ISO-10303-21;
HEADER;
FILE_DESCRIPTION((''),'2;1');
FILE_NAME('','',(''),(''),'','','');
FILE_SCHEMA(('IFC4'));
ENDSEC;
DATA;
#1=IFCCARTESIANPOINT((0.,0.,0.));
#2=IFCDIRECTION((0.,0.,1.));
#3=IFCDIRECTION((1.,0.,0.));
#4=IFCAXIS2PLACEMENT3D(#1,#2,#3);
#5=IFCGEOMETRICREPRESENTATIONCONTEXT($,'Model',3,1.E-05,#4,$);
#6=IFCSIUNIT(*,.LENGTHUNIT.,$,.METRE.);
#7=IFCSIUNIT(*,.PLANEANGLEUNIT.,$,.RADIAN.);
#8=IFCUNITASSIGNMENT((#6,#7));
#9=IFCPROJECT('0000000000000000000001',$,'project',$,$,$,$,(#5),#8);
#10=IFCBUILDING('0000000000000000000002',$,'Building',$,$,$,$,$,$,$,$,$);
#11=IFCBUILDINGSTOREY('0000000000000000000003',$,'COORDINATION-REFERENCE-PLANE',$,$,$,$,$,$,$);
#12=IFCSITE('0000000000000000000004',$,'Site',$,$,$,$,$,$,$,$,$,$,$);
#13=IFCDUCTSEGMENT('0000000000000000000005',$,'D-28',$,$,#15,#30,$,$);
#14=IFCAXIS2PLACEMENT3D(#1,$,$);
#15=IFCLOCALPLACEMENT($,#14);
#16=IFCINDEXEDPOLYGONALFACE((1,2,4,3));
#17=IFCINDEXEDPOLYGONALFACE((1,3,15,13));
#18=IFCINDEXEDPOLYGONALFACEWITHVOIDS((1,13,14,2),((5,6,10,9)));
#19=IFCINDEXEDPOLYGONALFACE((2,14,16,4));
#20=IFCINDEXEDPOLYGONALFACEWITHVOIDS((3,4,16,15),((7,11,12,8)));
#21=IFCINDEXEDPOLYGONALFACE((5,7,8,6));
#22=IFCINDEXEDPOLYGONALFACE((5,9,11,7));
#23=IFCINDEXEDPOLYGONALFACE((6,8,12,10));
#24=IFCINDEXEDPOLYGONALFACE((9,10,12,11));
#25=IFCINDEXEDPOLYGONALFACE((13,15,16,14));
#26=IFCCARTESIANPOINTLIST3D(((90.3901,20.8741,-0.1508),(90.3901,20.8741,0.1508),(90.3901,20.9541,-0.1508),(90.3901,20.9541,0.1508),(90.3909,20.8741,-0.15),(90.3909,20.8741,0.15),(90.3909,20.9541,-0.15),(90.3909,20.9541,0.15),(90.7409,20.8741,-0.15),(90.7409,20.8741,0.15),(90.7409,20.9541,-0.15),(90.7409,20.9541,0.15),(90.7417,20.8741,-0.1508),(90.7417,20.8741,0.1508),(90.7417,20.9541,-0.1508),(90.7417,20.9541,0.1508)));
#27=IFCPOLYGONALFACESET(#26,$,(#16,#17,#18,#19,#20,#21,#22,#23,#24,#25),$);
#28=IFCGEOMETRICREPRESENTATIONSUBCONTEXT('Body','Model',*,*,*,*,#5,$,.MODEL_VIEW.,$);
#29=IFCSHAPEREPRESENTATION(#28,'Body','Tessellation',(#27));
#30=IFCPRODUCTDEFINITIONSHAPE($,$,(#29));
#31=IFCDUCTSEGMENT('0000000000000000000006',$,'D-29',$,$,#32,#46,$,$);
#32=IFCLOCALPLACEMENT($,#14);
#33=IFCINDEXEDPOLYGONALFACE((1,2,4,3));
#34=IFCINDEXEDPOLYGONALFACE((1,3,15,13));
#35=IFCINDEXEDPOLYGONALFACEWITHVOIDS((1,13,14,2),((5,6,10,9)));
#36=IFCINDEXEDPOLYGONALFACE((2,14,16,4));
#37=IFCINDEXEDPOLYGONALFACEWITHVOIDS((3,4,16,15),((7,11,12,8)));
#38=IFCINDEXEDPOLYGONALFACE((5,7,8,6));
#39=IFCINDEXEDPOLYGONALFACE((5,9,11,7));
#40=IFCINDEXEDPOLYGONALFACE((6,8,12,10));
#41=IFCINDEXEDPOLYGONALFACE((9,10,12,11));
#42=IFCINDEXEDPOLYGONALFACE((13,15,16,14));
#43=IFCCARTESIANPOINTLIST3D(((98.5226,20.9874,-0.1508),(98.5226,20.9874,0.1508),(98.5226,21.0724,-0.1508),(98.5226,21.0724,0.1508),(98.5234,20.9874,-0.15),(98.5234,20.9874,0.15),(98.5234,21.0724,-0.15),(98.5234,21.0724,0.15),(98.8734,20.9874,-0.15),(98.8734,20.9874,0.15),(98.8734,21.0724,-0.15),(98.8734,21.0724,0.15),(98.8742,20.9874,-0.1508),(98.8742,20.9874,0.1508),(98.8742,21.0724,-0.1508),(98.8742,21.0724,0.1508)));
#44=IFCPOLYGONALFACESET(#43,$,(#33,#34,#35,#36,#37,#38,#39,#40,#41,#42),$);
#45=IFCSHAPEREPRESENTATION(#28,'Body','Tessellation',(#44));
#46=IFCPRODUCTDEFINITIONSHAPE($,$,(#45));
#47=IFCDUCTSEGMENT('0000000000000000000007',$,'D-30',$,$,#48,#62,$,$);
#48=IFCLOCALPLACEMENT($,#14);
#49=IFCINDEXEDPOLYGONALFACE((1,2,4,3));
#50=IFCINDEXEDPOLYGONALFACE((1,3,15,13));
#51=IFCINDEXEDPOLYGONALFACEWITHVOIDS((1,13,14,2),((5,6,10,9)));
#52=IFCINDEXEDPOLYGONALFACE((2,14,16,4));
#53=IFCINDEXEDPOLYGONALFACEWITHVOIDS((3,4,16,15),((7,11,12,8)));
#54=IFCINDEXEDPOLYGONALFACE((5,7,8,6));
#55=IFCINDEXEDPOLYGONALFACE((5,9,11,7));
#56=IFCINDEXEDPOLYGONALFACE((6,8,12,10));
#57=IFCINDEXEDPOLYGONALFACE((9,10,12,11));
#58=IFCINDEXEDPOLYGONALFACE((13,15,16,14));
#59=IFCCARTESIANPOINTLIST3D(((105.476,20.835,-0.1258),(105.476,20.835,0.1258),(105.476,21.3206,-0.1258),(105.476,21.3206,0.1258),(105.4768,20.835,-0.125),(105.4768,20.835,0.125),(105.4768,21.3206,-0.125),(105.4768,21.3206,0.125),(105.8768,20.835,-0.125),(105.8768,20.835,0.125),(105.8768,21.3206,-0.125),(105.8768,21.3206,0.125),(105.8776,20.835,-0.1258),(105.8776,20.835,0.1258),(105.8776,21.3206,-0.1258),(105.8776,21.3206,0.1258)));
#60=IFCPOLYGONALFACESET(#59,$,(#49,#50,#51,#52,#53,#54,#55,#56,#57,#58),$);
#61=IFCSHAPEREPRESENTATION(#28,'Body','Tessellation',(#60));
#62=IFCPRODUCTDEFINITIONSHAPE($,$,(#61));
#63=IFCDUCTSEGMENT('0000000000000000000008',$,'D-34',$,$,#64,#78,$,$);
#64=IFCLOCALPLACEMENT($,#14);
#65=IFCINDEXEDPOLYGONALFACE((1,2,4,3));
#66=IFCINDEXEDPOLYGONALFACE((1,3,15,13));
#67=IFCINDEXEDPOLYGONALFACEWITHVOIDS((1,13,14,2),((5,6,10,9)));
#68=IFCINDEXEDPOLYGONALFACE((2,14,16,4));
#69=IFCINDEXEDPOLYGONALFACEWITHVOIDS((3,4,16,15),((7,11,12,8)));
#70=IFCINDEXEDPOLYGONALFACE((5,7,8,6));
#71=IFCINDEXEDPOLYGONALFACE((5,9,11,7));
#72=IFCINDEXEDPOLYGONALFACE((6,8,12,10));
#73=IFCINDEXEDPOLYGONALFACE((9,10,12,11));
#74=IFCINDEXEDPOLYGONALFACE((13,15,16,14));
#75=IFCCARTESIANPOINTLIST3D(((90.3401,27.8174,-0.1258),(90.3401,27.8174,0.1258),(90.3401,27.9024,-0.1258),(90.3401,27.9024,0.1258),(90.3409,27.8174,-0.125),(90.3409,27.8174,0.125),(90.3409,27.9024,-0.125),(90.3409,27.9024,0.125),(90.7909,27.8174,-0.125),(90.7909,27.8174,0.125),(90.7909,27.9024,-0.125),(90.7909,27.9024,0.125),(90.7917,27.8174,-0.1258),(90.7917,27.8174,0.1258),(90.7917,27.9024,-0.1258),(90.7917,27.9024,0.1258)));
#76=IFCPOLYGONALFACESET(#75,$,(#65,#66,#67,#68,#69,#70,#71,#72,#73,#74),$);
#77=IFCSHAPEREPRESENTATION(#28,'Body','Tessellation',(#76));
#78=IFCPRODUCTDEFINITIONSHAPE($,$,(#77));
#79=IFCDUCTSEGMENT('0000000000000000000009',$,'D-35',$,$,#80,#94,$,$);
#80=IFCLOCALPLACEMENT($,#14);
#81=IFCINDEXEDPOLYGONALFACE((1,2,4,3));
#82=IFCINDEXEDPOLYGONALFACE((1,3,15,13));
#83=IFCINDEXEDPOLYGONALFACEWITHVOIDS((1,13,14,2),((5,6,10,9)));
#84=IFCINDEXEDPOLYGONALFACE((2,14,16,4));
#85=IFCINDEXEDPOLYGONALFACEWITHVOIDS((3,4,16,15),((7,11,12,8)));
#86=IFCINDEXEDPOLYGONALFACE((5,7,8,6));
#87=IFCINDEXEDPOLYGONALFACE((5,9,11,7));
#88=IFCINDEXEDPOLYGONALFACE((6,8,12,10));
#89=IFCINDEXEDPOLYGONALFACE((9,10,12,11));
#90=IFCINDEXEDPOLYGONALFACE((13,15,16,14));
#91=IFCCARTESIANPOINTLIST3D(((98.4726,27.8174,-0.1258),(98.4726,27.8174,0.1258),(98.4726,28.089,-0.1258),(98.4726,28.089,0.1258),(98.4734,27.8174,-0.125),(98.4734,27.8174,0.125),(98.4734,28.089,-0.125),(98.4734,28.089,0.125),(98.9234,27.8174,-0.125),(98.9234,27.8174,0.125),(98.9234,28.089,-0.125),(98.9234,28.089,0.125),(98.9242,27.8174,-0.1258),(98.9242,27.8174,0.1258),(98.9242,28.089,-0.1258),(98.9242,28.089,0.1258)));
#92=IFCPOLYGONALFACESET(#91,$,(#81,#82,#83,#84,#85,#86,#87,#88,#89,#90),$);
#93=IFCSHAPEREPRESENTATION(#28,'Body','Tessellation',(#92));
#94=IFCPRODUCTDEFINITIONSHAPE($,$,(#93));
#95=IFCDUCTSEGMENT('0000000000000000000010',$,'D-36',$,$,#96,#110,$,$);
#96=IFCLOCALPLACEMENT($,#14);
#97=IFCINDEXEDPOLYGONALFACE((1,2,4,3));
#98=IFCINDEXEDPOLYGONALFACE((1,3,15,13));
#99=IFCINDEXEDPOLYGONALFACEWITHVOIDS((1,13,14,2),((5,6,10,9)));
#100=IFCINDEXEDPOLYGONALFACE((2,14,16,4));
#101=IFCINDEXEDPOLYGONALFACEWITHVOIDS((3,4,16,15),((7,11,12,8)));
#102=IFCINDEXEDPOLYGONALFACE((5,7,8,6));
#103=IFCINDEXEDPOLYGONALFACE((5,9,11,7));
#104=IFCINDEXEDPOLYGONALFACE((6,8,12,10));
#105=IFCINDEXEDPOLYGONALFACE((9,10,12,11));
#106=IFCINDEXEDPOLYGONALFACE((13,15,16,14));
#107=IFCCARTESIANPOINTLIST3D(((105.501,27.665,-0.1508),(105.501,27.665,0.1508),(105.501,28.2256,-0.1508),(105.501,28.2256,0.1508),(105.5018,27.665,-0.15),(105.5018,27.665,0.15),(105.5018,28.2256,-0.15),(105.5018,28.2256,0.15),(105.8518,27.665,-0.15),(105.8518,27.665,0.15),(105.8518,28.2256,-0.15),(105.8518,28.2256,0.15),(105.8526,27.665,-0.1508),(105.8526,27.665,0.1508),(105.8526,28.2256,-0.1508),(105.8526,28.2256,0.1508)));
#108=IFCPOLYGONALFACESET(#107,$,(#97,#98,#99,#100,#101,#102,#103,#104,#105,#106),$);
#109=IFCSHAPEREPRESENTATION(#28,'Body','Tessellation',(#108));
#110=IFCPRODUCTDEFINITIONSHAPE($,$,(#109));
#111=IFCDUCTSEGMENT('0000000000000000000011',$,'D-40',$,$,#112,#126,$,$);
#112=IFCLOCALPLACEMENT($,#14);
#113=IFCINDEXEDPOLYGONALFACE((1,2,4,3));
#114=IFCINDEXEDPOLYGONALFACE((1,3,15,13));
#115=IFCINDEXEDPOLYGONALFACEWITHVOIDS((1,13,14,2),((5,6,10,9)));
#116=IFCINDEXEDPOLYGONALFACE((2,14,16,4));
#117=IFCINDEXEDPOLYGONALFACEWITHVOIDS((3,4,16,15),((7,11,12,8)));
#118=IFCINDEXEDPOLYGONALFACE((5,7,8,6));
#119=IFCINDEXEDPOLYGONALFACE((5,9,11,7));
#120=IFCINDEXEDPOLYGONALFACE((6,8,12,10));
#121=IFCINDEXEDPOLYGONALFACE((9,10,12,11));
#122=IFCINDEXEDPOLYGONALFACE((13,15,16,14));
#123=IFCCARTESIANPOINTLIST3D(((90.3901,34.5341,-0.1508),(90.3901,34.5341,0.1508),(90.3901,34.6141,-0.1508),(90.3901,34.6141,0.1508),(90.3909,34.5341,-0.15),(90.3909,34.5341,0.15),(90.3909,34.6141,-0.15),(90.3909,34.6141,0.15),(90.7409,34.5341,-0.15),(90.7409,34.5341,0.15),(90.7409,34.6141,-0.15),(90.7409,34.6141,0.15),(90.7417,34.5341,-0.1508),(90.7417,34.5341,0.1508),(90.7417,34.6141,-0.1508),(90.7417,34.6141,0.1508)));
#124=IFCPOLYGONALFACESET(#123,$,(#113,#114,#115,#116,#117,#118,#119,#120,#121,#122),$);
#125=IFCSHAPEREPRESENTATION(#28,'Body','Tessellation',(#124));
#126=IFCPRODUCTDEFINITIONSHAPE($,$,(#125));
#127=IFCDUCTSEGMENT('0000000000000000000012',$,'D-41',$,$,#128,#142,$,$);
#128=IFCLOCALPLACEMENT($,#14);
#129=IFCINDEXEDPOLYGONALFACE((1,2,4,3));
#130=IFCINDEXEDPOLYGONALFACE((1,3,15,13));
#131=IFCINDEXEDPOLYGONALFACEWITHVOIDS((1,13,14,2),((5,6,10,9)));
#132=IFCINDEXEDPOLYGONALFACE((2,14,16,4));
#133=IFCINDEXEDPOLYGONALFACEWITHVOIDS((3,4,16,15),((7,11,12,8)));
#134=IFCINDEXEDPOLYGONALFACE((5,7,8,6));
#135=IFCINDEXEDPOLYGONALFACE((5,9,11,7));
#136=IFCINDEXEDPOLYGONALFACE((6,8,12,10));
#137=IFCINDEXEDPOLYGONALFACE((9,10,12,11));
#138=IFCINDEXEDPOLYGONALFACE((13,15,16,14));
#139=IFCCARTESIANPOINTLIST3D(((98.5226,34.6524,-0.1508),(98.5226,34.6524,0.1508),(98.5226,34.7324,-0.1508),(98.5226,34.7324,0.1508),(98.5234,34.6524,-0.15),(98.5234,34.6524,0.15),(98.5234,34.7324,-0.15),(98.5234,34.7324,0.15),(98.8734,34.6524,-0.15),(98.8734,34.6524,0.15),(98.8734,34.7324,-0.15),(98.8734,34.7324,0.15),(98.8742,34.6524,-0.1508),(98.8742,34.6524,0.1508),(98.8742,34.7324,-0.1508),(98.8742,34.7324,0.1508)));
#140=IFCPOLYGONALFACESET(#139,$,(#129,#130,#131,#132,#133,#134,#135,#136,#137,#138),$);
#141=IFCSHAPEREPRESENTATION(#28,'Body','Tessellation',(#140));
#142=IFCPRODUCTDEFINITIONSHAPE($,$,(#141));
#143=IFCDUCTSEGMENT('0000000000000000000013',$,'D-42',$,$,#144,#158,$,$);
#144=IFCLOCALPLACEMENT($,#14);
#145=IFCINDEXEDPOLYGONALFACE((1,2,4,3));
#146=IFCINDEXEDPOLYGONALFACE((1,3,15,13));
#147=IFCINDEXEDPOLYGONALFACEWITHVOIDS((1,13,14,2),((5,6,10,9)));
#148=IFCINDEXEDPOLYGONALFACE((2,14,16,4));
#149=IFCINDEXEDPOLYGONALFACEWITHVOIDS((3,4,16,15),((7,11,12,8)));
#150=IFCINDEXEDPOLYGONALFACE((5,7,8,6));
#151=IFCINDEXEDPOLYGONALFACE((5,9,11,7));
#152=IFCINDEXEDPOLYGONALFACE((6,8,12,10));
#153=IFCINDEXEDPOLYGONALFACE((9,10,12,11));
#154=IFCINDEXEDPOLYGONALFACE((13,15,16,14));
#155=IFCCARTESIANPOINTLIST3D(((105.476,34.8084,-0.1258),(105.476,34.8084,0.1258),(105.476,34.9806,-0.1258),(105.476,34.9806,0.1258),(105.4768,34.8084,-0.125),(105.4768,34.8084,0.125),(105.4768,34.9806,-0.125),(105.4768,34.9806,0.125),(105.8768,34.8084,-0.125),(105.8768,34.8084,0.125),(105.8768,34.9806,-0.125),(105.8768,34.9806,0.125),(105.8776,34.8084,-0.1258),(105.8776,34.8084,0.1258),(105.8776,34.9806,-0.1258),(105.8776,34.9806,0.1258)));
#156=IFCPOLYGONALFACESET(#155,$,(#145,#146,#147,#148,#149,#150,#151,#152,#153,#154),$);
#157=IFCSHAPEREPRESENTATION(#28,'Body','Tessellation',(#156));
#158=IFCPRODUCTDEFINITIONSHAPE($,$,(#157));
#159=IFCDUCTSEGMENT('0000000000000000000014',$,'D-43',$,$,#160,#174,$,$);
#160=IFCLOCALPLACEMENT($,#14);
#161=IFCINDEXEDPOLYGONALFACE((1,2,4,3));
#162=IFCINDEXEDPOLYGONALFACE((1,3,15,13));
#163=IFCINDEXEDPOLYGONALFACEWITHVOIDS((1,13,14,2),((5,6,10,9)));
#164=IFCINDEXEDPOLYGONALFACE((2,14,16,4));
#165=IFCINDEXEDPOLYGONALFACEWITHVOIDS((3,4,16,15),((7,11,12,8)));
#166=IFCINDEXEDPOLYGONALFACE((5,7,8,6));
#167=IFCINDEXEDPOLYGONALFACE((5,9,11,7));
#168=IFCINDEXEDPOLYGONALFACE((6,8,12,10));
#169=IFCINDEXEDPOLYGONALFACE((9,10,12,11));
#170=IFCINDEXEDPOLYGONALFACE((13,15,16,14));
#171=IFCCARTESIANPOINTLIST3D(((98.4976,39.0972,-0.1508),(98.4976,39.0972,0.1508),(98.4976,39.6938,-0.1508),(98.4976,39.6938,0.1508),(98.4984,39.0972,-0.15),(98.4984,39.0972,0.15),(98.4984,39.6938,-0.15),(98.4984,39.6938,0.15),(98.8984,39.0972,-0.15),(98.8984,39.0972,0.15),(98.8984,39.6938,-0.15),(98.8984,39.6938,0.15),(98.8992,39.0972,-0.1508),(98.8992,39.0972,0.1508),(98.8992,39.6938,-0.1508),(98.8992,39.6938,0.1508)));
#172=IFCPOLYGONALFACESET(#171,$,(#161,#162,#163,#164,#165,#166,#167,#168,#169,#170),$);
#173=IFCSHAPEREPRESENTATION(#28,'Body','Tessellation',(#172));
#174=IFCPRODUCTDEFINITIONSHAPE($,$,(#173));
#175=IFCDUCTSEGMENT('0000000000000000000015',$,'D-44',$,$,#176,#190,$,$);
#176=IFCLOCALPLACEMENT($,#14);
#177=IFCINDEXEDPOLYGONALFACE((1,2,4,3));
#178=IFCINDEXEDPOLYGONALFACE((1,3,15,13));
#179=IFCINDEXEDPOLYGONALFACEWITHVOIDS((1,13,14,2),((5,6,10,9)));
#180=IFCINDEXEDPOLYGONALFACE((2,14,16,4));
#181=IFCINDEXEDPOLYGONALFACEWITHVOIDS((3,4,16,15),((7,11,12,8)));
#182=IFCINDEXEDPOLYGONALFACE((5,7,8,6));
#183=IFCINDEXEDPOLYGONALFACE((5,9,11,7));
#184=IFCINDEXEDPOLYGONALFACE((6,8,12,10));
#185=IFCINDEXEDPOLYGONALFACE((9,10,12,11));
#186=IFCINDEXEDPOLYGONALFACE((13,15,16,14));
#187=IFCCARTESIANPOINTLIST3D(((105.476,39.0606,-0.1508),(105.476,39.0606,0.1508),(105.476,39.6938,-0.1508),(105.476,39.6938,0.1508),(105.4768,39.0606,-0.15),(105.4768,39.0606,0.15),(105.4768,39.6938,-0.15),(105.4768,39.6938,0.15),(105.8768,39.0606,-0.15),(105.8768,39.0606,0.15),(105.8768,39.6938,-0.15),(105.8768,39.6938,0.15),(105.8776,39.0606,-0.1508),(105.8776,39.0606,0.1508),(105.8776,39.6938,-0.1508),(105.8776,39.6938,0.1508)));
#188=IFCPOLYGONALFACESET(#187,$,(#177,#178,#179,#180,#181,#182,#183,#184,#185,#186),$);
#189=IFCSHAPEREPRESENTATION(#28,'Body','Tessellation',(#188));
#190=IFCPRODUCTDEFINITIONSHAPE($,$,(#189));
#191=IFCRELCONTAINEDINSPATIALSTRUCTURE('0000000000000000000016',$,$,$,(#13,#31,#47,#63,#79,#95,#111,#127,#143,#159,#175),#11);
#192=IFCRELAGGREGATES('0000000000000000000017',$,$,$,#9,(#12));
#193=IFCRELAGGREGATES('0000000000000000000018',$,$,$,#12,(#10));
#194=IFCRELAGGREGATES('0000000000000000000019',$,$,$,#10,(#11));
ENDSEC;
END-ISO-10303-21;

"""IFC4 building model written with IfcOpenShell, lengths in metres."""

from ifc_helpers import new_model, si_unit, frame, origin, origin_with_axes, place, context, subcontext, project, spatial, hollow_rectangle, extrude, element, save


model = new_model("IFC4")

# Units and contexts
model_context = context("Model", 3, precision=1e-05, world=origin_with_axes())
body_context = subcontext(model_context, "Body", "Model", "MODEL_VIEW")
ifc_project = project(units=[si_unit("LENGTHUNIT", "METRE"), si_unit("PLANEANGLEUNIT", "RADIAN")], contexts=[model_context])

# Site, building, storey
site = spatial("IfcSite", under=ifc_project, Name="Site")
building = spatial("IfcBuilding", under=site, Name="Building")
storey = spatial("IfcBuildingStorey", under=building, Name="COORDINATION-REFERENCE-PLANE")

# Duct segments
duct_segment_1_placement = place(None, frame((90.5659, 20.8741, 0.0), z_axis=(0.0, 1.0, 0.0), x_axis=(1.0, 0.0, 0.0)))
element("IfcDuctSegment", 1, at=duct_segment_1_placement, inside=storey, Name="D-28", context=body_context, shape_type="SweptSolid", body=[
    extrude(hollow_rectangle(XDim=0.3516, YDim=0.3016, WallThickness=0.0008), origin(), (0.0, 0.0, 1.0), 0.08),
])
duct_segment_2_placement = place(None, frame((98.6984, 20.9874, 0.0), z_axis=(0.0, 1.0, 0.0), x_axis=(1.0, 0.0, 0.0)))
element("IfcDuctSegment", 2, at=duct_segment_2_placement, inside=storey, Name="D-29", context=body_context, shape_type="SweptSolid", body=[
    extrude(hollow_rectangle(XDim=0.3516, YDim=0.3016, WallThickness=0.0008), origin(), (0.0, 0.0, 1.0), 0.085),
])
duct_segment_3_placement = place(None, frame((105.6768, 20.835, 0.0), z_axis=(0.0, 1.0, 0.0), x_axis=(1.0, 0.0, 0.0)))
element("IfcDuctSegment", 3, at=duct_segment_3_placement, inside=storey, Name="D-30", context=body_context, shape_type="SweptSolid", body=[
    extrude(hollow_rectangle(XDim=0.4016, YDim=0.2516, WallThickness=0.0008), origin(), (0.0, 0.0, 1.0), 0.4856),
])
duct_segment_4_placement = place(None, frame((90.5659, 27.8174, 0.0), z_axis=(0.0, 1.0, 0.0), x_axis=(1.0, 0.0, 0.0)))
element("IfcDuctSegment", 4, at=duct_segment_4_placement, inside=storey, Name="D-34", context=body_context, shape_type="SweptSolid", body=[
    extrude(hollow_rectangle(XDim=0.4516, YDim=0.2516, WallThickness=0.0008), origin(), (0.0, 0.0, 1.0), 0.085),
])
duct_segment_5_placement = place(None, frame((98.6984, 27.8174, 0.0), z_axis=(0.0, 1.0, 0.0), x_axis=(1.0, 0.0, 0.0)))
element("IfcDuctSegment", 5, at=duct_segment_5_placement, inside=storey, Name="D-35", context=body_context, shape_type="SweptSolid", body=[
    extrude(hollow_rectangle(XDim=0.4516, YDim=0.2516, WallThickness=0.0008), origin(), (0.0, 0.0, 1.0), 0.2716),
])
duct_segment_6_placement = place(None, frame((105.6768, 27.665, 0.0), z_axis=(0.0, 1.0, 0.0), x_axis=(1.0, 0.0, 0.0)))
element("IfcDuctSegment", 6, at=duct_segment_6_placement, inside=storey, Name="D-36", context=body_context, shape_type="SweptSolid", body=[
    extrude(hollow_rectangle(XDim=0.3516, YDim=0.3016, WallThickness=0.0008), origin(), (0.0, 0.0, 1.0), 0.5606),
])
for number, where, z_axis, x_axis, name in (
    (7, (90.5659, 34.5341, 0.0), (0.0, 1.0, 0.0), (1.0, 0.0, 0.0), "D-40"),
    (8, (98.6984, 34.6524, 0.0), (0.0, 1.0, 0.0), (1.0, 0.0, 0.0), "D-41"),
):
    element("IfcDuctSegment", number, at=place(None, frame(where, z_axis=z_axis, x_axis=x_axis)), inside=storey, Name=name, context=body_context, shape_type="SweptSolid", body=[
        extrude(hollow_rectangle(XDim=0.3516, YDim=0.3016, WallThickness=0.0008), origin(), (0.0, 0.0, 1.0), 0.08),
    ])
duct_segment_7_placement = place(None, frame((105.6768, 34.8084, 0.0), z_axis=(0.0, 1.0, 0.0), x_axis=(1.0, 0.0, 0.0)))
element("IfcDuctSegment", 9, at=duct_segment_7_placement, inside=storey, Name="D-42", context=body_context, shape_type="SweptSolid", body=[
    extrude(hollow_rectangle(XDim=0.4016, YDim=0.2516, WallThickness=0.0008), origin(), (0.0, 0.0, 1.0), 0.1721),
])
duct_segment_8_placement = place(None, frame((98.6984, 39.0972, 0.0), z_axis=(0.0, 1.0, 0.0), x_axis=(1.0, 0.0, 0.0)))
element("IfcDuctSegment", 10, at=duct_segment_8_placement, inside=storey, Name="D-43", context=body_context, shape_type="SweptSolid", body=[
    extrude(hollow_rectangle(XDim=0.4016, YDim=0.3016, WallThickness=0.0008), origin(), (0.0, 0.0, 1.0), 0.5966),
])
duct_segment_9_placement = place(None, frame((105.6768, 39.0606, 0.0), z_axis=(0.0, 1.0, 0.0), x_axis=(1.0, 0.0, 0.0)))
element("IfcDuctSegment", 11, at=duct_segment_9_placement, inside=storey, Name="D-44", context=body_context, shape_type="SweptSolid", body=[
    extrude(hollow_rectangle(XDim=0.4016, YDim=0.3016, WallThickness=0.0008), origin(), (0.0, 0.0, 1.0), 0.6332),
])

save(model, "model.ifc")
